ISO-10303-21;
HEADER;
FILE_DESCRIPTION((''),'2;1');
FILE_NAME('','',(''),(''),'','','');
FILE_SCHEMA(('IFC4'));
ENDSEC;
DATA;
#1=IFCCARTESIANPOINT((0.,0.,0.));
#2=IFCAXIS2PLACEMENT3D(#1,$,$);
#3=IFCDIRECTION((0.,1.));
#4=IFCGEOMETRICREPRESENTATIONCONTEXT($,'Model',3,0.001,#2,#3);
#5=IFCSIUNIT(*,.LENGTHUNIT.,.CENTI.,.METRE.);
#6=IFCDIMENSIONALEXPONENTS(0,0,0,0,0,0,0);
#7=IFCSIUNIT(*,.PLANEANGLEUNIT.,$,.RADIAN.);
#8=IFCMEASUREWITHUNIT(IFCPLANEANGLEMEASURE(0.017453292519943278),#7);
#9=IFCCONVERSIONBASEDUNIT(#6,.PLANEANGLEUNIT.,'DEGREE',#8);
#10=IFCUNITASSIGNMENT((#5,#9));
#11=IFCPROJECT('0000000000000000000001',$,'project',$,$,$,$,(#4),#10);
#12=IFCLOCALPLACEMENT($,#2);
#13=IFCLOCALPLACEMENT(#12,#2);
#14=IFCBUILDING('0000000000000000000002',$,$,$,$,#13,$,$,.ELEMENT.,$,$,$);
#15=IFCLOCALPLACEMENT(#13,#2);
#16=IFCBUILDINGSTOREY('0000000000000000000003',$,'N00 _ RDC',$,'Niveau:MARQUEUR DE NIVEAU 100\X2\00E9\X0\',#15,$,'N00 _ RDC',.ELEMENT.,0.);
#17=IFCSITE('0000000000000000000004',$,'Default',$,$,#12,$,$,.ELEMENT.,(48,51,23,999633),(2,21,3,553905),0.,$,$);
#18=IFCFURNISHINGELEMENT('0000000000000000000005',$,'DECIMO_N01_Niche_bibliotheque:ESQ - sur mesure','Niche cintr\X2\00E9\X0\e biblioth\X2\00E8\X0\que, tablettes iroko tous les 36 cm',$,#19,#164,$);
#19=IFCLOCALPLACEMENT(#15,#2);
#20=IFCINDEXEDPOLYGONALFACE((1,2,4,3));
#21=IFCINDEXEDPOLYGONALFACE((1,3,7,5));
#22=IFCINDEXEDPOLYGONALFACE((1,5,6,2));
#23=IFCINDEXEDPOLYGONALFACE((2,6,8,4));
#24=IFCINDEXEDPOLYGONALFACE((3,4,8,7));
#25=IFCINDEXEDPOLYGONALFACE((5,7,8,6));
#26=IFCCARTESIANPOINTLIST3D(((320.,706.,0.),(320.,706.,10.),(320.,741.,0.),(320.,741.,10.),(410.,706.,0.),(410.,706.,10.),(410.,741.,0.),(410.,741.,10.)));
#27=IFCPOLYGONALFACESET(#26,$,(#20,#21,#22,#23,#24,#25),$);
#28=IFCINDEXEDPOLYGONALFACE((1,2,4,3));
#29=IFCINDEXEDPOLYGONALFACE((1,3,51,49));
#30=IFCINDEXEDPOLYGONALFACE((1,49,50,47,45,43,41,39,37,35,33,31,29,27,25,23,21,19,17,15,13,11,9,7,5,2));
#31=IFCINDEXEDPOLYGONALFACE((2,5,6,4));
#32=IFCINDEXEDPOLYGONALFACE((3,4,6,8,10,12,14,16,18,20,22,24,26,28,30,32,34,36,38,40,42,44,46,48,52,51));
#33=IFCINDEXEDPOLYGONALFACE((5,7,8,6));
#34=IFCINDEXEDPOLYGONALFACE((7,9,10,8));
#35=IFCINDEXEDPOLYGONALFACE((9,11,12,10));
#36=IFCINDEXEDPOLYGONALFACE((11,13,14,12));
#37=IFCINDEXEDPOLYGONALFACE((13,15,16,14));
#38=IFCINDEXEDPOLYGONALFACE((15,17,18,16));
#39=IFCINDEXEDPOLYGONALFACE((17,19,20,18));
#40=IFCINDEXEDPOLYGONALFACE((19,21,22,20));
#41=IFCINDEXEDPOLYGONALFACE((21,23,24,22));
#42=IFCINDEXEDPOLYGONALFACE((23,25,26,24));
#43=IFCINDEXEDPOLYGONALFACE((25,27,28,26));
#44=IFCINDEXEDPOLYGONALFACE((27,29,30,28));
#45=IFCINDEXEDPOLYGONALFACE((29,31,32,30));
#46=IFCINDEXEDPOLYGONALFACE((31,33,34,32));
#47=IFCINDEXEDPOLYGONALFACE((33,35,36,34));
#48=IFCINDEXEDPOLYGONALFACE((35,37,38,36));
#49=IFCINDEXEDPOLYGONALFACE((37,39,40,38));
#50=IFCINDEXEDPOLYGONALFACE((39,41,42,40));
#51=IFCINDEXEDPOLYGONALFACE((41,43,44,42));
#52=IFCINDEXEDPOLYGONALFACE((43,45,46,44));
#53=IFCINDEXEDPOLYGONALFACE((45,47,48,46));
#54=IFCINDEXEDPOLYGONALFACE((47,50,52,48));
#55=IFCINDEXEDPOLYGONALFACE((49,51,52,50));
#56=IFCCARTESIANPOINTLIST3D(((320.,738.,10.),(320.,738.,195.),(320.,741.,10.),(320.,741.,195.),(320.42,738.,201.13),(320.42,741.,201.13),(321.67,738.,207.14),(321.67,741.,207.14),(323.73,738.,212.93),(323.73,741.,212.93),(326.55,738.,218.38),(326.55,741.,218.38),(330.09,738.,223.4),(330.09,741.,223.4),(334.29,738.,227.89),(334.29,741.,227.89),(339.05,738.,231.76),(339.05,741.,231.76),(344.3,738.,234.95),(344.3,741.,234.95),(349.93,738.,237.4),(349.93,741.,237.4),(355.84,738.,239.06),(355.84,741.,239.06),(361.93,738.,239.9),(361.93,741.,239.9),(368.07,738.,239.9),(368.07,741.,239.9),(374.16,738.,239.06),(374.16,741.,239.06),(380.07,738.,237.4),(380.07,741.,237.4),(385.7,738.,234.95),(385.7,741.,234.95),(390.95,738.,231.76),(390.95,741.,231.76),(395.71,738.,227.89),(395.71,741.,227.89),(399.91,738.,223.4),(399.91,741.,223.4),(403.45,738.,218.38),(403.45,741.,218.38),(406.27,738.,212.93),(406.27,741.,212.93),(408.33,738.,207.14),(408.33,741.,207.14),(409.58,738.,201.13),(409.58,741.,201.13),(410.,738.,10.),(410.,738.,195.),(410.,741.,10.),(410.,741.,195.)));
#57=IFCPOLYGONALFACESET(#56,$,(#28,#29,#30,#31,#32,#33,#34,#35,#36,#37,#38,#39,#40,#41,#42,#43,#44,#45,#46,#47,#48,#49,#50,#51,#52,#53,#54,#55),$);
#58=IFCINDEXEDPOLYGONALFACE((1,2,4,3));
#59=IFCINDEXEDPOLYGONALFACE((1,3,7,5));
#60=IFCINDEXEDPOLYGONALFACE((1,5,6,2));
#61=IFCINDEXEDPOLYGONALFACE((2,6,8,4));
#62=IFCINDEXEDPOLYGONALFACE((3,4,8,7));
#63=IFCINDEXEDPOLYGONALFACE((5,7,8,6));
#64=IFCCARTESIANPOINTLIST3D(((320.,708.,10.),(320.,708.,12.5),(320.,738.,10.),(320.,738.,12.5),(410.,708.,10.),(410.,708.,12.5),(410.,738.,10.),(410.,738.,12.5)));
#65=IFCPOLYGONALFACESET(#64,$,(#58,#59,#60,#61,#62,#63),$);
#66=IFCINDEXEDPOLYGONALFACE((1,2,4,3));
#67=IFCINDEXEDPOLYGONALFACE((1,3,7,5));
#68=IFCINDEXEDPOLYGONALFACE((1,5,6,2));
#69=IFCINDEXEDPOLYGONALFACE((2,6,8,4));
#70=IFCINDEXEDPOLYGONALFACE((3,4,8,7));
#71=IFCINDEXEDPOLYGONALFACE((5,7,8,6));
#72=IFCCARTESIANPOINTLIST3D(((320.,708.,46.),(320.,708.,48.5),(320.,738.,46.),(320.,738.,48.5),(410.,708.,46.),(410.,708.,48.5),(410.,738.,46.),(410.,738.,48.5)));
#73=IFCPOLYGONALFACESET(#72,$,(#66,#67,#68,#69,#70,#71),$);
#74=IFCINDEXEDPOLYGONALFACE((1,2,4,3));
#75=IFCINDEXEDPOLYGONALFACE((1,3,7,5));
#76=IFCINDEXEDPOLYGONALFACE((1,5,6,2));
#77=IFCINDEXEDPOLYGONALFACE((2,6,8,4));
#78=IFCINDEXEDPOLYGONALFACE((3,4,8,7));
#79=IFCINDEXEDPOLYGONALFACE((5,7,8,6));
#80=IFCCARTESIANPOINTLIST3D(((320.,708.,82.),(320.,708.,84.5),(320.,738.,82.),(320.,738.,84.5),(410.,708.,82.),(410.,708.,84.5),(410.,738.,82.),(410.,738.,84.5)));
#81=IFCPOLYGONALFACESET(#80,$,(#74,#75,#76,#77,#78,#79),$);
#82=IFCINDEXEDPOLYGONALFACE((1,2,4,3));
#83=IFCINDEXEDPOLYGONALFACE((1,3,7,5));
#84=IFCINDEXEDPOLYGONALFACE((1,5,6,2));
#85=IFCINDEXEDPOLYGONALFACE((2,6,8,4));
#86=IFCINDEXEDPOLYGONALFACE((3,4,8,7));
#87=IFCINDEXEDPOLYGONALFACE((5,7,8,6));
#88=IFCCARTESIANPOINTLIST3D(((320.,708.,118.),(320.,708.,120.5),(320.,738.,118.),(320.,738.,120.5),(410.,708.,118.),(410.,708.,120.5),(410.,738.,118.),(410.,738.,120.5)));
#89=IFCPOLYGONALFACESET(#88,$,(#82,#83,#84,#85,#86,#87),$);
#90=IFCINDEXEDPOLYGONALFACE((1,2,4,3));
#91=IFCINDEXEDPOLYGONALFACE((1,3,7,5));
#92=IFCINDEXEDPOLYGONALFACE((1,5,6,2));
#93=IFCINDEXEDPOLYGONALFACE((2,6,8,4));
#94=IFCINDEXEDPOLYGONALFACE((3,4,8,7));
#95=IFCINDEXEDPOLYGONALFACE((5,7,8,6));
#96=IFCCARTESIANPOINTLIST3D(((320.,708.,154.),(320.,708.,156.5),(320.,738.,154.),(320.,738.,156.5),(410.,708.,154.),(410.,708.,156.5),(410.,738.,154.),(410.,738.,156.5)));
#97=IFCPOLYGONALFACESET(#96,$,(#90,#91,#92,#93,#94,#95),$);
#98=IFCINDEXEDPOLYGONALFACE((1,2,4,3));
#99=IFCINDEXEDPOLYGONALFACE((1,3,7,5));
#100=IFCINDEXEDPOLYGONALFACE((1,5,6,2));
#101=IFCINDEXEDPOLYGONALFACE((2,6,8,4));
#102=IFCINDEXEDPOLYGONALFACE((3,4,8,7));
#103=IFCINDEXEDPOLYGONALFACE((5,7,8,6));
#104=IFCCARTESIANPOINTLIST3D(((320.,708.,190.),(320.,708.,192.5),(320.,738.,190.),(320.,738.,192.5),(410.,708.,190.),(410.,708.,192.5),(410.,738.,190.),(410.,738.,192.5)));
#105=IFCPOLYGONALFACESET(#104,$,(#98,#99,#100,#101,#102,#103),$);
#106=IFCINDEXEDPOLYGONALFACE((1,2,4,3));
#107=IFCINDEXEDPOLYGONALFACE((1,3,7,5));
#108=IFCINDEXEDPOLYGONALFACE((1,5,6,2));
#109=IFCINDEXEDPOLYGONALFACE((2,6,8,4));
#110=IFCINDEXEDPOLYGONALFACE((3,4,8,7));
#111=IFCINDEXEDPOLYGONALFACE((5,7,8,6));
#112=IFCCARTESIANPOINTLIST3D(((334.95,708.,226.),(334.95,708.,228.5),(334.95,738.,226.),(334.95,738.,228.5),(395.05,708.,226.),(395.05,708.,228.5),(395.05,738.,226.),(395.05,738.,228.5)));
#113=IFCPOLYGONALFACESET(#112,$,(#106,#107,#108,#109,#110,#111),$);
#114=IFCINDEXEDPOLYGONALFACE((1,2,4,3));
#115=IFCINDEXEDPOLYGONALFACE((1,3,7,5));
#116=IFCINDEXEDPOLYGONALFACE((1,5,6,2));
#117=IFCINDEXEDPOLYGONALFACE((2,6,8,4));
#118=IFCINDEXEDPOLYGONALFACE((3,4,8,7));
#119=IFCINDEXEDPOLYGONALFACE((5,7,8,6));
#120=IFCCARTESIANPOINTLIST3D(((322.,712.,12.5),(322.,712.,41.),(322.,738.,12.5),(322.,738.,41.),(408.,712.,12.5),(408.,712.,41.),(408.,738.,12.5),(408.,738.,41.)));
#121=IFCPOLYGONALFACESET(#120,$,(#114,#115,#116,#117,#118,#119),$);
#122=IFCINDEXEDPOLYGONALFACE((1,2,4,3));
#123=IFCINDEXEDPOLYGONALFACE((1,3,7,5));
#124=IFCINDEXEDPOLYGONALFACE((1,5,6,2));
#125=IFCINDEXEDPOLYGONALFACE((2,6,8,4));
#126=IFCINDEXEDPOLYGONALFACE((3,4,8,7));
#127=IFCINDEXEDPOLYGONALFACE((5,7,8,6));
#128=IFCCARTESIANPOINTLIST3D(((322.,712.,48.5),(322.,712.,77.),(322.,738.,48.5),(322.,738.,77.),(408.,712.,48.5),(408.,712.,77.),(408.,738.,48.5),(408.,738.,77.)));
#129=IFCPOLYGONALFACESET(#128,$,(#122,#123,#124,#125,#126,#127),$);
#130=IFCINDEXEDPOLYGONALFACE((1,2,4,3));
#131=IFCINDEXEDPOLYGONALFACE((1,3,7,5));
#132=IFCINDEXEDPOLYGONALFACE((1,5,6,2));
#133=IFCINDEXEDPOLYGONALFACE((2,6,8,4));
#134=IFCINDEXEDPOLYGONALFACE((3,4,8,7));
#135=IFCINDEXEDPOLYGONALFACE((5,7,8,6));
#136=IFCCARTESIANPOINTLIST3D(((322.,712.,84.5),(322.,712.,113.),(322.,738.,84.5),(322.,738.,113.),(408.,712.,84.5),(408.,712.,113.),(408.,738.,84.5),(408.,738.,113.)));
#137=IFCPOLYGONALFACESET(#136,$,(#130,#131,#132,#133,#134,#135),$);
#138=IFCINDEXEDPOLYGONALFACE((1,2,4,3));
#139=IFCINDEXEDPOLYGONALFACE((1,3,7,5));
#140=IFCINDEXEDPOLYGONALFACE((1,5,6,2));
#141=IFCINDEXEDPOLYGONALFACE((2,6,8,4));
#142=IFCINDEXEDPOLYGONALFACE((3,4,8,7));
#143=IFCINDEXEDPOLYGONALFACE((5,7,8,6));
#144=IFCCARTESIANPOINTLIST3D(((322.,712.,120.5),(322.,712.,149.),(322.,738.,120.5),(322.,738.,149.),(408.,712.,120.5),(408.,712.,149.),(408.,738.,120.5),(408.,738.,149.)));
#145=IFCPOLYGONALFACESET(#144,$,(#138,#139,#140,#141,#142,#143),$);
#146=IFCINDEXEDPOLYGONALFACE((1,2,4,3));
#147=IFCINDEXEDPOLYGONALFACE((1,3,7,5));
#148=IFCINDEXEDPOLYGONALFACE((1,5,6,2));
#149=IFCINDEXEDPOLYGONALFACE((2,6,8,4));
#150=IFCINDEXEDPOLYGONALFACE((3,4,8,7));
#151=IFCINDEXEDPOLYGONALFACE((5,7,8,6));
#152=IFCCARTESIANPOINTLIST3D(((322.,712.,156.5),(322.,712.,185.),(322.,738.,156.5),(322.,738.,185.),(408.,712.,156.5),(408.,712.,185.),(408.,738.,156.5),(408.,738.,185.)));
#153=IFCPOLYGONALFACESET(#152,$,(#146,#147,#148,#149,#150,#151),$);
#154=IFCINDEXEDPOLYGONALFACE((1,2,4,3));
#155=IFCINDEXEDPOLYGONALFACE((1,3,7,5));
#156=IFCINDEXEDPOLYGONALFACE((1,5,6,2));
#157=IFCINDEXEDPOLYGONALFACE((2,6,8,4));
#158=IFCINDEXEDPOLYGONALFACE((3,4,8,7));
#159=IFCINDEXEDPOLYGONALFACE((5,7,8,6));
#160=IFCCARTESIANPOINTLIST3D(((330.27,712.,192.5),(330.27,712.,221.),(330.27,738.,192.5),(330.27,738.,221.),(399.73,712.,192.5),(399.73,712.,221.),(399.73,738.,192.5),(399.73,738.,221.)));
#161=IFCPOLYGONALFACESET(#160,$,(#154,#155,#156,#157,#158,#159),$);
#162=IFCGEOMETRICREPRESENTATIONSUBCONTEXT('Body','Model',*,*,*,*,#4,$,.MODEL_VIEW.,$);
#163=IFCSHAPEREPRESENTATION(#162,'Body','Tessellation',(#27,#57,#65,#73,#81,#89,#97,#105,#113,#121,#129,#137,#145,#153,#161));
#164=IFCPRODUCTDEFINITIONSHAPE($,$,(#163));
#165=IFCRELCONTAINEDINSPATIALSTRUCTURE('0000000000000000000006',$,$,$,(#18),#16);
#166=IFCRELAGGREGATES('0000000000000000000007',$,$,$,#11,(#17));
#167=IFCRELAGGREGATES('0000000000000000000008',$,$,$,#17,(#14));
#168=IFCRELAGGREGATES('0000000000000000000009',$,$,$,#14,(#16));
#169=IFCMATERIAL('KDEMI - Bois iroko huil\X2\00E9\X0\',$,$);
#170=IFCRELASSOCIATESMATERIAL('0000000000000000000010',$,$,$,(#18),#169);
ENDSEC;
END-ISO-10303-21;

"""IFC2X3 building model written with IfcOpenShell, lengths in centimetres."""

from ifc_helpers import new_model, entity, si_unit, converted_unit, direction, frame, frame_2d, origin, origin_with_axes, place, context, subcontext, project, spatial, polyline, rectangle, outline, extrude, material, element, save


model = new_model("IFC2X3")

# Units and contexts
model_context = context("Model", 3, precision=0.001, world=origin(), true_north=direction((0.0, 1.0)))
body_context = subcontext(model_context, "Body", "Model", "MODEL_VIEW")
ifc_project = project(units=[si_unit("LENGTHUNIT", "METRE", prefix="CENTI"), converted_unit("PLANEANGLEUNIT", "DEGREE", entity("IfcPlaneAngleMeasure", 0.017453292519943278), si_unit("PLANEANGLEUNIT", "RADIAN"), dimensions=[0, 0, 0, 0, 0, 0, 0])], contexts=[model_context])

# Site, building, storey
site_placement = place(None, origin())
site = spatial("IfcSite", under=ifc_project, at=site_placement, Name="Default", CompositionType="ELEMENT", RefLatitude=(48, 51, 23, 999633), RefLongitude=(2, 21, 3, 553905), RefElevation=0.0)
building_placement = place(site_placement, origin())
building = spatial("IfcBuilding", under=site, at=building_placement, CompositionType="ELEMENT")
storey_placement = place(building_placement, origin())
storey = spatial("IfcBuildingStorey", under=building, at=storey_placement, Name="N00 _ RDC", ObjectType="Niveau:MARQUEUR DE NIVEAU 100é", LongName="N00 _ RDC", CompositionType="ELEMENT", Elevation=0.0)

# Furnishing element
ifc_material_1 = material(Name="KDEMI - Bois iroko huilé")
furnishing_1_placement = place(storey_placement, origin_with_axes())
element("IfcFurnishingElement", 1, at=furnishing_1_placement, inside=storey, material=ifc_material_1, Name="DECIMO_N01_Niche_bibliotheque:ESQ - sur mesure", Description="Niche cintrée bibliothèque, tablettes iroko tous les 36 cm", context=body_context, shape_type="SweptSolid", body=[
    extrude(rectangle(XDim=90.0, YDim=35.0, at=frame_2d((365.0, 723.5))), origin(), (0.0, 0.0, 1.0), 10.0),
    extrude(outline(polyline([(320.0, 10.0), (410.0, 10.0), (410.0, 195.0), (409.58, 201.13), (408.33, 207.14), (406.27, 212.93), (403.45, 218.38), (399.91, 223.4), (395.71, 227.89), (390.95, 231.76), (385.7, 234.95), (380.07, 237.4), (374.16, 239.06), (368.07, 239.9), (361.93, 239.9), (355.84, 239.06), (349.93, 237.4), (344.3, 234.95), (339.05, 231.76), (334.29, 227.89), (330.09, 223.4), (326.55, 218.38), (323.73, 212.93), (321.67, 207.14), (320.42, 201.13), (320.0, 195.0), (320.0, 10.0)])), frame((0.0, 741.0, 0.0), z_axis=(0.0, -1.0, 0.0), x_axis=(1.0, 0.0, 0.0)), (0.0, 0.0, 1.0), 3.0),
    extrude(rectangle(XDim=90.0, YDim=30.0, at=frame_2d((365.0, 723.0))), frame((0.0, 0.0, 10.0)), (0.0, 0.0, 1.0), 2.5),
    extrude(rectangle(XDim=90.0, YDim=30.0, at=frame_2d((365.0, 723.0))), frame((0.0, 0.0, 46.0)), (0.0, 0.0, 1.0), 2.5),
    extrude(rectangle(XDim=90.0, YDim=30.0, at=frame_2d((365.0, 723.0))), frame((0.0, 0.0, 82.0)), (0.0, 0.0, 1.0), 2.5),
    extrude(rectangle(XDim=90.0, YDim=30.0, at=frame_2d((365.0, 723.0))), frame((0.0, 0.0, 118.0)), (0.0, 0.0, 1.0), 2.5),
    extrude(rectangle(XDim=90.0, YDim=30.0, at=frame_2d((365.0, 723.0))), frame((0.0, 0.0, 154.0)), (0.0, 0.0, 1.0), 2.5),
    extrude(rectangle(XDim=90.0, YDim=30.0, at=frame_2d((365.0, 723.0))), frame((0.0, 0.0, 190.0)), (0.0, 0.0, 1.0), 2.5),
    extrude(rectangle(XDim=60.09, YDim=30.0, at=frame_2d((365.0, 723.0))), frame((0.0, 0.0, 226.0)), (0.0, 0.0, 1.0), 2.5),
    extrude(rectangle(XDim=86.0, YDim=26.0, at=frame_2d((365.0, 725.0))), frame((0.0, 0.0, 12.5)), (0.0, 0.0, 1.0), 28.5),
    extrude(rectangle(XDim=86.0, YDim=26.0, at=frame_2d((365.0, 725.0))), frame((0.0, 0.0, 48.5)), (0.0, 0.0, 1.0), 28.5),
    extrude(rectangle(XDim=86.0, YDim=26.0, at=frame_2d((365.0, 725.0))), frame((0.0, 0.0, 84.5)), (0.0, 0.0, 1.0), 28.5),
    extrude(rectangle(XDim=86.0, YDim=26.0, at=frame_2d((365.0, 725.0))), frame((0.0, 0.0, 120.5)), (0.0, 0.0, 1.0), 28.5),
    extrude(rectangle(XDim=86.0, YDim=26.0, at=frame_2d((365.0, 725.0))), frame((0.0, 0.0, 156.5)), (0.0, 0.0, 1.0), 28.5),
    extrude(rectangle(XDim=69.46, YDim=26.0, at=frame_2d((365.0, 725.0))), frame((0.0, 0.0, 192.5)), (0.0, 0.0, 1.0), 28.5),
])

save(model, "model.ifc")
